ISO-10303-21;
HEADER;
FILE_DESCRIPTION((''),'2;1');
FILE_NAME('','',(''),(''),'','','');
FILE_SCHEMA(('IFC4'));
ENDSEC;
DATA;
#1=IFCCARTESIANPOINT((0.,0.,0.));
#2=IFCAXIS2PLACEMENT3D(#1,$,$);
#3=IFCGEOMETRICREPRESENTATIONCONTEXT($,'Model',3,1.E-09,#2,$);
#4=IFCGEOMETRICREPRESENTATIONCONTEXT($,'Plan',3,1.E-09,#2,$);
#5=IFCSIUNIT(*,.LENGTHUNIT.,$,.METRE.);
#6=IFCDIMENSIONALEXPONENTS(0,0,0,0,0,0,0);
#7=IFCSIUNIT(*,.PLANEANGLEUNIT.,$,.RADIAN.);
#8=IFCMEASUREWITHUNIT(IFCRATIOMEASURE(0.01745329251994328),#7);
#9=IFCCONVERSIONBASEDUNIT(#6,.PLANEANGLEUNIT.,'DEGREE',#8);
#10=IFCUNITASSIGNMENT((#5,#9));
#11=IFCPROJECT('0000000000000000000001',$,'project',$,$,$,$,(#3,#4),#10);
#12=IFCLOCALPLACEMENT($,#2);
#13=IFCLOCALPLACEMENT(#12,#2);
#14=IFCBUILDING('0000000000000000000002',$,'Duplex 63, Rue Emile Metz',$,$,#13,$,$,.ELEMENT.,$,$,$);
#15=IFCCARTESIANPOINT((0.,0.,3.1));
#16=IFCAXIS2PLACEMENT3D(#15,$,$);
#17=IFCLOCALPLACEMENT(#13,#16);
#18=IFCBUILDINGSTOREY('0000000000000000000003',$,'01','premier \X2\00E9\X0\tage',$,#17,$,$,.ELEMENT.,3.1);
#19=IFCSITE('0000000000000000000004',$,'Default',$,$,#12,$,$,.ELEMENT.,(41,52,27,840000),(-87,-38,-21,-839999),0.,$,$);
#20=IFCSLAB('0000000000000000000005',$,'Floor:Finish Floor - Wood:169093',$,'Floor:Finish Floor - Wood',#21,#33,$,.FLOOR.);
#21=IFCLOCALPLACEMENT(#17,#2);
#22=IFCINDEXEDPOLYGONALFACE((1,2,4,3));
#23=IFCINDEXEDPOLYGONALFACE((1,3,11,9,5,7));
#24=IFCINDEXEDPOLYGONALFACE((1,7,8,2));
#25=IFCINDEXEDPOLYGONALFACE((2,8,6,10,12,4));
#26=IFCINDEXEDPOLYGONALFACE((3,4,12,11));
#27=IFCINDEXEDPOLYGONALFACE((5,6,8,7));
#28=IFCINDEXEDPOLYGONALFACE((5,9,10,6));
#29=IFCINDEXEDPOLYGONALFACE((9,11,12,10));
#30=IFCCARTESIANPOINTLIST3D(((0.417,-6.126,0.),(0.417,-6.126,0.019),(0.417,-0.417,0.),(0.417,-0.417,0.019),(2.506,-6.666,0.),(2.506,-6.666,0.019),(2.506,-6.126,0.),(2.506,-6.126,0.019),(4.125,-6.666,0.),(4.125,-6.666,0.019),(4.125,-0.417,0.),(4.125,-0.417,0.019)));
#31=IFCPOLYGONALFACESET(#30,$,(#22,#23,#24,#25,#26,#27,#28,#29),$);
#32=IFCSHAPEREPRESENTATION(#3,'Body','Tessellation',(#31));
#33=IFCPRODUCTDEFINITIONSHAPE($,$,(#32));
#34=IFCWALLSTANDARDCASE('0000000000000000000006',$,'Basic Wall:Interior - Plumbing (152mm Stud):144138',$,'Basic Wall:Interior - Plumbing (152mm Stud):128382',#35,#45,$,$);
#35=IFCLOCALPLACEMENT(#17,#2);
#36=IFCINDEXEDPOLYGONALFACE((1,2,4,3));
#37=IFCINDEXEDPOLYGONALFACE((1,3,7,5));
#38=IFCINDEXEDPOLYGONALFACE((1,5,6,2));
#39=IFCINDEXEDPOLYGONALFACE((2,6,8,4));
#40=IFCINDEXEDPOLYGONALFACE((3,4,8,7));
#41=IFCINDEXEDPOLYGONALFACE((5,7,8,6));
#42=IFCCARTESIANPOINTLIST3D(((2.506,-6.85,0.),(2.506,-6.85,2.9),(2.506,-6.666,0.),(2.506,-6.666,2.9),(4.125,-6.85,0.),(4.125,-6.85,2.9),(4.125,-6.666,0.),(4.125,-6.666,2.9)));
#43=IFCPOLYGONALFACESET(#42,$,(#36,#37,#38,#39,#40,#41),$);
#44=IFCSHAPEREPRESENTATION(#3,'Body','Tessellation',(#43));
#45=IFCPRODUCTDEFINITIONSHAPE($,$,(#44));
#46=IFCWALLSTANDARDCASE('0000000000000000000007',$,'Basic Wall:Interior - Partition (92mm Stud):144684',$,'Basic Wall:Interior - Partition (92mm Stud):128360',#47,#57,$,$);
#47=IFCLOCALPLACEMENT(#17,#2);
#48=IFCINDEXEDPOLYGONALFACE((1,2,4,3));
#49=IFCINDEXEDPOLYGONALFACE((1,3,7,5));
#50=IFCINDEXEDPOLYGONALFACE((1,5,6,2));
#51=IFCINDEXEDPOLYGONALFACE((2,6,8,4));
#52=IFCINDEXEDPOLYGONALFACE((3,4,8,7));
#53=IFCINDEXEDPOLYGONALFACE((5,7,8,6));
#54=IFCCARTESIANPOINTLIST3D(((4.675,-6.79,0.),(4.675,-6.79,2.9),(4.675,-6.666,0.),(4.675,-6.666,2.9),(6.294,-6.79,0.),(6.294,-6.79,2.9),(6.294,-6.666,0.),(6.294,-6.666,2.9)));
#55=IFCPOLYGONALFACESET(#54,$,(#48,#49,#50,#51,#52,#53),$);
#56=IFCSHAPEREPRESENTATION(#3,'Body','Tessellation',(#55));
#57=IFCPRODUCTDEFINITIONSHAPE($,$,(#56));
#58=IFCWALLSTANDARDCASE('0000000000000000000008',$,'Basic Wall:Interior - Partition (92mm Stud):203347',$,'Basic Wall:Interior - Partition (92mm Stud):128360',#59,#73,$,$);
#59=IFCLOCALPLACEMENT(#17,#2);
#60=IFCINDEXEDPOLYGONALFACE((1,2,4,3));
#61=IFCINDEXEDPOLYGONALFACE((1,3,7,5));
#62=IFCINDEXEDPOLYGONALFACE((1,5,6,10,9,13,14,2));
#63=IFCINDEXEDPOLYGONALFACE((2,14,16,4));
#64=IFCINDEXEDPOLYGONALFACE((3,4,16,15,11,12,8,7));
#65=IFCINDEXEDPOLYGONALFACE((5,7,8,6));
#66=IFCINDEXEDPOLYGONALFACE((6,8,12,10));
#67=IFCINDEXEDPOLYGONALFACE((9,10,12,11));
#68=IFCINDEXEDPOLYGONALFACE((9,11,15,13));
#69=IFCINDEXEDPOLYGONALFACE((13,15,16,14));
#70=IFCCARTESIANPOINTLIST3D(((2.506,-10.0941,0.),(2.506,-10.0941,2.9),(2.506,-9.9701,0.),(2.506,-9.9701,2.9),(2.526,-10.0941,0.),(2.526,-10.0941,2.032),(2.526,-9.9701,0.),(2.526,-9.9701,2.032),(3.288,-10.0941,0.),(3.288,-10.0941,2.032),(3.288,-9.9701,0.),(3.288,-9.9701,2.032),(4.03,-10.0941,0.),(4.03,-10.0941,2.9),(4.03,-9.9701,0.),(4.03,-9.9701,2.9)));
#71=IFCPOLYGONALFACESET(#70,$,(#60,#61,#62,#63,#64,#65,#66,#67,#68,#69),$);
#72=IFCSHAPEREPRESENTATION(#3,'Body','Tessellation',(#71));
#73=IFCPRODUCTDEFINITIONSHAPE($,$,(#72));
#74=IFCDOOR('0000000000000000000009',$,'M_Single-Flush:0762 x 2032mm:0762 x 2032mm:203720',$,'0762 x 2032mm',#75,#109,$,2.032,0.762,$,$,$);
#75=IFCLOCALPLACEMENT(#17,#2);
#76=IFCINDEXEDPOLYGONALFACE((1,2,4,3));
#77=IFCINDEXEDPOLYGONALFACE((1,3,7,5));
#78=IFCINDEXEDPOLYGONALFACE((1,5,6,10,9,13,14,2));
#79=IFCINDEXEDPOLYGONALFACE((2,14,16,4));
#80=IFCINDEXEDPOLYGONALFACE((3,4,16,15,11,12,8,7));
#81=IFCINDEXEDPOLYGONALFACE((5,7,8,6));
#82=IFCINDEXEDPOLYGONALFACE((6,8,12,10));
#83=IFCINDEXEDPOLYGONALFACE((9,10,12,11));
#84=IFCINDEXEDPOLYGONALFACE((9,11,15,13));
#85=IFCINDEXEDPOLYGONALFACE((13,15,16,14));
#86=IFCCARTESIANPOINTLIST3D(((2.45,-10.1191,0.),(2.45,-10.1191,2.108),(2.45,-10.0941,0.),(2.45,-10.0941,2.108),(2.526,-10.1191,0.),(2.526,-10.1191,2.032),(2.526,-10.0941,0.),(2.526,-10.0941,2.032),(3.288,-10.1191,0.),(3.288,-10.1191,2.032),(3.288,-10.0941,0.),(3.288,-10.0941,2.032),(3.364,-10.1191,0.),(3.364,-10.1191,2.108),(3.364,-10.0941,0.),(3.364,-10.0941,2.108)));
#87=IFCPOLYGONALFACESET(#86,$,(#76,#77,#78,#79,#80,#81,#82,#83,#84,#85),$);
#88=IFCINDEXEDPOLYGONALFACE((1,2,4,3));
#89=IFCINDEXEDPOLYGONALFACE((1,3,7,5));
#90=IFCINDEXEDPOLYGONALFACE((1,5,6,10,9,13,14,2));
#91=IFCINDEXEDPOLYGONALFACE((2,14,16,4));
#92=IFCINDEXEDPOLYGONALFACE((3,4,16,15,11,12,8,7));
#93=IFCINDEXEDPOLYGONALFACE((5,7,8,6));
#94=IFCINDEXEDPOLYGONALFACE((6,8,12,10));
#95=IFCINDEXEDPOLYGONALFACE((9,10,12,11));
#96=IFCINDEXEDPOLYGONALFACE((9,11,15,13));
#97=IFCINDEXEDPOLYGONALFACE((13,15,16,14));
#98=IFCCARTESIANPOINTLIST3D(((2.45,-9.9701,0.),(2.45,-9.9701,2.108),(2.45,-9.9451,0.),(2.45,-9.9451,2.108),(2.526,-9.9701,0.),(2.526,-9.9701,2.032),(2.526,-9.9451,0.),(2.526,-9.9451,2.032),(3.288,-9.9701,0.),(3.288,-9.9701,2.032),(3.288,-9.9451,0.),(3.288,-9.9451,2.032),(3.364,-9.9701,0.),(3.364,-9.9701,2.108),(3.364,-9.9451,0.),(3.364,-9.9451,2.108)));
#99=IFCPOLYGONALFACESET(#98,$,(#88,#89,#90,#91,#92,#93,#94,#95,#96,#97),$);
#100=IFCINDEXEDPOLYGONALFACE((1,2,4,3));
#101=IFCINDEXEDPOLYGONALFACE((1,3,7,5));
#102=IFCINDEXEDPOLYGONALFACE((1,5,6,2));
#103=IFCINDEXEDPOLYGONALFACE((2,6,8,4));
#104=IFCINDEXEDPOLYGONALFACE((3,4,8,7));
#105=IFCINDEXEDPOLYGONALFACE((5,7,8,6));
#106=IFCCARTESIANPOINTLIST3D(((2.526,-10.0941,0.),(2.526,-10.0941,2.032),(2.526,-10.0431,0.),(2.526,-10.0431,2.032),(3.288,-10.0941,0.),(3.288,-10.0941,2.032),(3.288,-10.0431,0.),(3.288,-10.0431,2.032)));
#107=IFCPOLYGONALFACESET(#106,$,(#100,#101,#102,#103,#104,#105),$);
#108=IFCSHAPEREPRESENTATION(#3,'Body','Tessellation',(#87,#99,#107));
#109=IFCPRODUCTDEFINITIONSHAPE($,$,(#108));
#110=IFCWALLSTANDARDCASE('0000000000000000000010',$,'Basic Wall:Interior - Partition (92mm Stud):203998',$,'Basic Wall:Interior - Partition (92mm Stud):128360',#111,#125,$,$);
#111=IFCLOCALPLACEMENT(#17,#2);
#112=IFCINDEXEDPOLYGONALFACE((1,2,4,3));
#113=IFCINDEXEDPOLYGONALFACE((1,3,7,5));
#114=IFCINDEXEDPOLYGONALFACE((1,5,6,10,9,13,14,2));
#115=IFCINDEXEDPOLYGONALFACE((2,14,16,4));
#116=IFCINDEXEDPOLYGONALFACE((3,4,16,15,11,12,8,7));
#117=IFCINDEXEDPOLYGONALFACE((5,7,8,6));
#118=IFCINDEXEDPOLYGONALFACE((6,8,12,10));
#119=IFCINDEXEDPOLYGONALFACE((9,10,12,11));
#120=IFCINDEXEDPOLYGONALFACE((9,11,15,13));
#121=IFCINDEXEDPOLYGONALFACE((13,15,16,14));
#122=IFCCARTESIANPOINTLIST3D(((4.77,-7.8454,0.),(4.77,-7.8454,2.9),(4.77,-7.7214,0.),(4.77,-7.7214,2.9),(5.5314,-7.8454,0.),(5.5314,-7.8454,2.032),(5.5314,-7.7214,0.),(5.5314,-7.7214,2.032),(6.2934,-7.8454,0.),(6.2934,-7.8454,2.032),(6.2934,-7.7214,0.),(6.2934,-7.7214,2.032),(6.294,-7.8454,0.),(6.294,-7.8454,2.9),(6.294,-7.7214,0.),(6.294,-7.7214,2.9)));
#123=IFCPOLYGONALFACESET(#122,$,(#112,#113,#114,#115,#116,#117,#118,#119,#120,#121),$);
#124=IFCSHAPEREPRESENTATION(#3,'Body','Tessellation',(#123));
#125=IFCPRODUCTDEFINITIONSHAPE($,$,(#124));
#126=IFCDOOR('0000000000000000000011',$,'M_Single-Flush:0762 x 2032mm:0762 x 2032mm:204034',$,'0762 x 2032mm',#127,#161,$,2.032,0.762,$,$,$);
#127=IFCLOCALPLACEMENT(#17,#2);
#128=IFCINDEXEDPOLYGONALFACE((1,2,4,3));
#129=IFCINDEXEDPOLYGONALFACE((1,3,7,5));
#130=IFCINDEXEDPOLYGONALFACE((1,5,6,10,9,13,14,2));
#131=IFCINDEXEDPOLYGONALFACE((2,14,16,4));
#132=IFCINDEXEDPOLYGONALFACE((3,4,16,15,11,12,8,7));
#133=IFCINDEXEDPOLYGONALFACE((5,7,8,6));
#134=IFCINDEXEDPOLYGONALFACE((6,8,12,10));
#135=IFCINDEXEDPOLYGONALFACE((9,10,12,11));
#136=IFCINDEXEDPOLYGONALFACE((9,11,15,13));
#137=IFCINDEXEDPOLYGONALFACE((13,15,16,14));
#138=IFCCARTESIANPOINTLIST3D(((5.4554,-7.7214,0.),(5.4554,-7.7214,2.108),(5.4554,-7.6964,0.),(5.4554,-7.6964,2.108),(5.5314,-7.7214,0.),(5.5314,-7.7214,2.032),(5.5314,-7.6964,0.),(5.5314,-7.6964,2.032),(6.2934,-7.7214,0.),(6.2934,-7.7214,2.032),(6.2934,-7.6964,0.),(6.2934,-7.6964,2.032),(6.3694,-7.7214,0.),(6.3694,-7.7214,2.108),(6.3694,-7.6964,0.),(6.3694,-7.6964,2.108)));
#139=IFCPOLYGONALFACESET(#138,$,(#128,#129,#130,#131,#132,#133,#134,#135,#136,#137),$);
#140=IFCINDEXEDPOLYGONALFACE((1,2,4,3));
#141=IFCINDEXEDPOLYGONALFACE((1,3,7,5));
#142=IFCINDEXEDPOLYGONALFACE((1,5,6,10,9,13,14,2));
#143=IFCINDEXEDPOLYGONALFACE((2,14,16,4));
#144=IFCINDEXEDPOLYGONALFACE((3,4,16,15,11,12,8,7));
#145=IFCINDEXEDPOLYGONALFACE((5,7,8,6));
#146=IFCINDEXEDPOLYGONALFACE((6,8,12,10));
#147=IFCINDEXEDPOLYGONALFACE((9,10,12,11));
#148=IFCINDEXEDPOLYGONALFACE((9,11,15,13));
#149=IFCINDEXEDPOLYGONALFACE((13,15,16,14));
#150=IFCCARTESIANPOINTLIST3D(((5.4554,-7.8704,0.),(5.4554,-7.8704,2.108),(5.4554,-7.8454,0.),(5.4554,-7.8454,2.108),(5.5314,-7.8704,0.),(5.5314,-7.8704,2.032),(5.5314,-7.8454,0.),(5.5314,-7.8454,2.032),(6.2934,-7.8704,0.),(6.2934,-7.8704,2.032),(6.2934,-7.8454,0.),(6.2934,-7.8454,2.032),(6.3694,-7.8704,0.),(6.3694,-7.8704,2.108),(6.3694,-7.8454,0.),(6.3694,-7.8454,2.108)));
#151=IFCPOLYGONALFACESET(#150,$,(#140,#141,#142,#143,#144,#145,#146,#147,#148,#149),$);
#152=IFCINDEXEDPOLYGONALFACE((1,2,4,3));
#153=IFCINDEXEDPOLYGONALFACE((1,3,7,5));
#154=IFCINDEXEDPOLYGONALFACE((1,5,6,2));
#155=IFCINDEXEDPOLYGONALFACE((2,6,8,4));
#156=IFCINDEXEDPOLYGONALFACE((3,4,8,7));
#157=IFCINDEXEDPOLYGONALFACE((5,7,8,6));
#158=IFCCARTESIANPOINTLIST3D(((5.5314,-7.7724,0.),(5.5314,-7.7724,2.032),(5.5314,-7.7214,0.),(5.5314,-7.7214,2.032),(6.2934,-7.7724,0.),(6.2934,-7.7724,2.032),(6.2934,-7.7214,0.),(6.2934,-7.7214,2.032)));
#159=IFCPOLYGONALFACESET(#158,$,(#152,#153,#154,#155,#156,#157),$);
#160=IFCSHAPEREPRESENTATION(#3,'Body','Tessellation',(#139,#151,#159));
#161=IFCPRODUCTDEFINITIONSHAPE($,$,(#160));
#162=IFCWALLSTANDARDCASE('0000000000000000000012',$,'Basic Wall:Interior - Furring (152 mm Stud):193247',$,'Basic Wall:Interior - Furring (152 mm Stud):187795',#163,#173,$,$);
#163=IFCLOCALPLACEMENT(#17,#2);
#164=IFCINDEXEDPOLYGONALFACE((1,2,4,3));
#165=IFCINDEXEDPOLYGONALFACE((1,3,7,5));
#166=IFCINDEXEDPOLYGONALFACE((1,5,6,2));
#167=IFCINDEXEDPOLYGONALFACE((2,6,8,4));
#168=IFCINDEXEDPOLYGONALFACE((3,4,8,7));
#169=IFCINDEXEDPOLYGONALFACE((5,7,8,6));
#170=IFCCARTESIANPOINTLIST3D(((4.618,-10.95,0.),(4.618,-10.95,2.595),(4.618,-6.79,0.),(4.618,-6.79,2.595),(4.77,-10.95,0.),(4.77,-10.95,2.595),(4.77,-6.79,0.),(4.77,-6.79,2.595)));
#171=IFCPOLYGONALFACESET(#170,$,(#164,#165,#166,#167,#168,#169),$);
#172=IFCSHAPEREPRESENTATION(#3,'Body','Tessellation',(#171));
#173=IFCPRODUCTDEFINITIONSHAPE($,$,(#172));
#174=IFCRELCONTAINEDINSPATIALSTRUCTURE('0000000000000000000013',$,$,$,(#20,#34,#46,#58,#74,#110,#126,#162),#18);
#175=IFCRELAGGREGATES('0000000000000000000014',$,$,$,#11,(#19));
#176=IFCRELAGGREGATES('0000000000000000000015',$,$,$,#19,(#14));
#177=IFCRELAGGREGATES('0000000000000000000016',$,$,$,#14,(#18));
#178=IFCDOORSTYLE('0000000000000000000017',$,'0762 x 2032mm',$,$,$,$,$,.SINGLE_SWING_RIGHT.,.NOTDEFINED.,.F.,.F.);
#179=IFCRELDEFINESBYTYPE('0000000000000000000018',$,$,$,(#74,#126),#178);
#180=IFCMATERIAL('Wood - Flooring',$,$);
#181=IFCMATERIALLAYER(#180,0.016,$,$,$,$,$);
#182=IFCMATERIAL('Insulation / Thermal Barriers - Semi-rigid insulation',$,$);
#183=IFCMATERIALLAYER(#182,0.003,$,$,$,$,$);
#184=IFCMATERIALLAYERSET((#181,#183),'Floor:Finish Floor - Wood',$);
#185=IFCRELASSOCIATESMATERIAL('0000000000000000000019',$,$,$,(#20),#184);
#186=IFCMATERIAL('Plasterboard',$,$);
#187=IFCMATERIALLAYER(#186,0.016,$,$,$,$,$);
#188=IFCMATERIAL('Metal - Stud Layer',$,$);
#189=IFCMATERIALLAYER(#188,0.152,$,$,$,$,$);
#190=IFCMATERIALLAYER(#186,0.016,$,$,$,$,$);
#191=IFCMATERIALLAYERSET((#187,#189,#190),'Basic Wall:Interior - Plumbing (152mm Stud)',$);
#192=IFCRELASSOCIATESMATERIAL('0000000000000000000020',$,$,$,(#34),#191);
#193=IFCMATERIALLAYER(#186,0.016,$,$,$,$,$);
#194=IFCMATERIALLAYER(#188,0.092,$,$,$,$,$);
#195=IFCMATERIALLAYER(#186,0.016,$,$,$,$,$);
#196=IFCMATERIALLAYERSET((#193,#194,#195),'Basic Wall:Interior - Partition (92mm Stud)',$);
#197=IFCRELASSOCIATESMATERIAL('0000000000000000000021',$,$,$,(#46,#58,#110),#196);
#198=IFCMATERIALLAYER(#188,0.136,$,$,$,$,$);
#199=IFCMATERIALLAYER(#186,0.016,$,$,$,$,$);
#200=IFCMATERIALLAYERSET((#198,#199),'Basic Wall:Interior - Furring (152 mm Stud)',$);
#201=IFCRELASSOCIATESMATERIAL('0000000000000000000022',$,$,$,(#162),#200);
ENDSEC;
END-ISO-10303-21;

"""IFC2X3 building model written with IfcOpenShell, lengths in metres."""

from ifc_helpers import new_model, entity, si_unit, converted_unit, frame, frame_2d, origin, origin_2d_with_axis, place, context, project, spatial, polyline, rectangle, outline, extrude, source, transform, mapped, material, layer, layer_set, layer_usage, type_object, type_shapes, element, fill, save


model = new_model("IFC2X3")

# Units and contexts
model_context = context("Model", 3, precision=1e-09, world=origin())
plan_context = context("Plan", 3, precision=1e-09, world=origin())
ifc_project = project(units=[si_unit("LENGTHUNIT", "METRE"), converted_unit("PLANEANGLEUNIT", "DEGREE", entity("IfcRatioMeasure", 0.01745329251994328), si_unit("PLANEANGLEUNIT", "RADIAN"), dimensions=[0, 0, 0, 0, 0, 0, 0])], contexts=[model_context, plan_context])

# Site, building, storey
site_placement = place(None, origin())
site = spatial("IfcSite", under=ifc_project, at=site_placement, Name="Default", CompositionType="ELEMENT", RefLatitude=(41, 52, 27, 840000), RefLongitude=(-87, -38, -21, -839999), RefElevation=0.0)
building_placement = place(site_placement, origin())
building = spatial("IfcBuilding", under=site, at=building_placement, Name="Duplex 63, Rue Emile Metz", CompositionType="ELEMENT")
storey_placement = place(building_placement, frame((0.0, 0.0, 3.1)))
storey = spatial("IfcBuildingStorey", under=building, at=storey_placement, Name="01", Description="premier étage", CompositionType="ELEMENT", Elevation=3.1)

# Slab
ifc_material_1 = material(Name="Wood - Flooring")
ifc_layer_1 = layer(ifc_material_1, 0.016)
ifc_material_2 = material(Name="Insulation / Thermal Barriers - Semi-rigid insulation")
ifc_layer_2 = layer(ifc_material_2, 0.003)
ifc_layer_set_1 = layer_set([ifc_layer_1, ifc_layer_2], Name="Floor:Finish Floor - Wood")
ifc_layer_usage_1 = layer_usage(ifc_layer_set_1, "AXIS3", "POSITIVE", 0.0)
slab_placement = place(storey_placement, frame((0.417, -6.666, 0.0)))
element("IfcSlab", 1, at=slab_placement, inside=storey, material=ifc_layer_usage_1, Name="Floor:Finish Floor - Wood:169093", ObjectType="Floor:Finish Floor - Wood", PredefinedType="FLOOR", context=model_context, shape_type="SweptSolid", body=[
    extrude(outline(polyline([(1.854, 3.1245), (-1.854, 3.1245), (-1.854, -3.1245), (-0.235, -3.1245), (-0.235, -2.5845), (1.854, -2.5845), (1.854, 3.1245)])), frame((1.854, 3.1245, 0.019), z_axis=(0.0, 0.0, -1.0), x_axis=(-1.0, 0.0, 0.0)), (0.0, 0.0, 1.0), 0.019),
])

# Walls
ifc_material_3 = material(Name="Plasterboard")
ifc_layer_3 = layer(ifc_material_3, 0.016)
ifc_material_4 = material(Name="Metal - Stud Layer")
ifc_layer_4 = layer(ifc_material_4, 0.152)
ifc_layer_5 = layer(ifc_material_3, 0.016)
ifc_layer_set_2 = layer_set([ifc_layer_3, ifc_layer_4, ifc_layer_5], Name="Basic Wall:Interior - Plumbing (152mm Stud)")
ifc_layer_usage_2 = layer_usage(ifc_layer_set_2, "AXIS2", "NEGATIVE", 0.092)
wall_1_placement = place(storey_placement, frame((2.506, -6.758, 0.0)))
element("IfcWallStandardCase", 2, at=wall_1_placement, inside=storey, material=ifc_layer_usage_2, Name="Basic Wall:Interior - Plumbing (152mm Stud):144138", ObjectType="Basic Wall:Interior - Plumbing (152mm Stud):128382", context=model_context, shape_type="SweptSolid", body=[
    extrude(rectangle(XDim=1.619, YDim=0.184, at=frame_2d((0.8095, 0.0), x_axis=(-1.0, 0.0))), origin(), (0.0, 0.0, 1.0), 2.9),
])
ifc_layer_6 = layer(ifc_material_3, 0.016)
ifc_layer_7 = layer(ifc_material_4, 0.092)
ifc_layer_8 = layer(ifc_material_3, 0.016)
ifc_layer_set_3 = layer_set([ifc_layer_6, ifc_layer_7, ifc_layer_8], Name="Basic Wall:Interior - Partition (92mm Stud)")
ifc_layer_usage_3 = layer_usage(ifc_layer_set_3, "AXIS2", "NEGATIVE", 0.062)
wall_2_placement = place(storey_placement, frame((4.675, -6.728, 0.0)))
element("IfcWallStandardCase", 3, at=wall_2_placement, inside=storey, material=ifc_layer_usage_3, Name="Basic Wall:Interior - Partition (92mm Stud):144684", ObjectType="Basic Wall:Interior - Partition (92mm Stud):128360", context=model_context, shape_type="SweptSolid", body=[
    extrude(rectangle(XDim=1.619, YDim=0.124, at=frame_2d((0.8095, 0.0), x_axis=(-1.0, 0.0))), origin(), (0.0, 0.0, 1.0), 2.9),
])

# Walls, openings, doors
wall_3_placement = place(storey_placement, frame((4.03, -10.0321, 0.0), z_axis=(0.0, 0.0, 1.0), x_axis=(-1.0, 0.0, 0.0)))
wall_3 = element("IfcWallStandardCase", 4, at=wall_3_placement, inside=storey, material=ifc_layer_usage_3, Name="Basic Wall:Interior - Partition (92mm Stud):203347", ObjectType="Basic Wall:Interior - Partition (92mm Stud):128360", context=model_context, shape_type="SweptSolid", body=[
    extrude(rectangle(XDim=1.524, YDim=0.124, at=frame_2d((0.762, 0.0), x_axis=(-1.0, 0.0))), origin(), (0.0, 0.0, 1.0), 2.9),
])
opening_1_placement = place(wall_3_placement, frame((0.742, -0.062, 0.0)))
opening_1 = element("IfcOpeningElement", 5, at=opening_1_placement, cuts=wall_3, ObjectType="Opening", context=model_context, shape_type="SweptSolid", body=[
    extrude(rectangle(XDim=0.762, YDim=2.032, at=frame_2d((1.016, 0.381), x_axis=(0.0, 1.0))), frame((0.0, 0.0, 0.0), z_axis=(0.0, 1.0, 0.0), x_axis=(0.0, 0.0, 1.0)), (0.0, 0.0, 1.0), 0.124),
])
door_style = type_object("IfcDoorStyle", Name="0762 x 2032mm", ConstructionType="NOTDEFINED", OperationType="SINGLE_SWING_RIGHT", ParameterTakesPrecedence=False, Sizeable=False)
shared_shape = source(origin(), model_context, "Body", "SweptSolid", [
    extrude(outline(polyline([(-0.457, -1.073), (0.457, -1.073), (0.457, 1.035), (0.381, 1.035), (0.381, -0.997), (-0.381, -0.997), (-0.381, 1.035), (-0.457, 1.035), (-0.457, -1.073)])), frame((0.381, 0.124, 1.035), z_axis=(0.0, 1.0, 0.0), x_axis=(1.0, 0.0, 0.0)), (0.0, 0.0, 1.0), 0.025),
    extrude(outline(polyline([(-1.073, -0.457), (1.035, -0.457), (1.035, -0.381), (-0.997, -0.381), (-0.997, 0.381), (1.035, 0.381), (1.035, 0.457), (-1.073, 0.457), (-1.073, -0.457)])), frame((0.381, -0.025, 1.035), z_axis=(0.0, 1.0, 0.0), x_axis=(0.0, 0.0, -1.0)), (0.0, 0.0, 1.0), 0.025),
    extrude(rectangle(XDim=0.051, YDim=0.762, at=origin_2d_with_axis()), frame((0.381, 0.0985, 0.0), z_axis=(0.0, 0.0, 1.0), x_axis=(0.0, 1.0, 0.0)), (0.0, 0.0, 1.0), 2.032),
])
type_shapes(door_style, [shared_shape])
door_1_placement = place(opening_1_placement, origin())
door_1 = element("IfcDoor", 6, at=door_1_placement, inside=storey, type_object=door_style, Name="M_Single-Flush:0762 x 2032mm:0762 x 2032mm:203720", ObjectType="0762 x 2032mm", OverallHeight=2.032, OverallWidth=0.762, context=model_context, shape_type="MappedRepresentation", body=[
    mapped(shared_shape, transform((0.0, 0.0, 0.0), scale=1.0)),
])
fill(opening_1, door_1)
ifc_layer_usage_4 = layer_usage(ifc_layer_set_3, "AXIS2", "POSITIVE", -0.062)
wall_4_placement = place(storey_placement, frame((4.77, -7.7834, 0.0)))
wall_4 = element("IfcWallStandardCase", 7, at=wall_4_placement, inside=storey, material=ifc_layer_usage_4, Name="Basic Wall:Interior - Partition (92mm Stud):203998", ObjectType="Basic Wall:Interior - Partition (92mm Stud):128360", context=model_context, shape_type="SweptSolid", body=[
    extrude(rectangle(XDim=1.524, YDim=0.124, at=frame_2d((0.762, 0.0), x_axis=(-1.0, 0.0))), origin(), (0.0, 0.0, 1.0), 2.9),
])
opening_2_placement = place(wall_4_placement, frame((0.7614, -0.062, 0.0)))
opening_2 = element("IfcOpeningElement", 8, at=opening_2_placement, cuts=wall_4, ObjectType="Opening", context=model_context, shape_type="SweptSolid", body=[
    extrude(rectangle(XDim=0.762, YDim=2.032, at=frame_2d((1.016, 0.381), x_axis=(0.0, 1.0))), frame((0.0, 0.0, 0.0), z_axis=(0.0, 1.0, 0.0), x_axis=(0.0, 0.0, 1.0)), (0.0, 0.0, 1.0), 0.124),
])
door_2_placement = place(opening_2_placement, origin())
door_2 = element("IfcDoor", 9, at=door_2_placement, inside=storey, type_object=door_style, Name="M_Single-Flush:0762 x 2032mm:0762 x 2032mm:204034", ObjectType="0762 x 2032mm", OverallHeight=2.032, OverallWidth=0.762, context=model_context, shape_type="MappedRepresentation", body=[
    mapped(shared_shape, transform((0.0, 0.0, 0.0), scale=1.0)),
])
fill(opening_2, door_2)

# Wall
ifc_layer_9 = layer(ifc_material_4, 0.136)
ifc_layer_10 = layer(ifc_material_3, 0.016)
ifc_layer_set_4 = layer_set([ifc_layer_9, ifc_layer_10], Name="Basic Wall:Interior - Furring (152 mm Stud)")
ifc_layer_usage_5 = layer_usage(ifc_layer_set_4, "AXIS2", "POSITIVE", -0.076)
wall_5_placement = place(storey_placement, frame((4.694, -6.79, 0.0), z_axis=(0.0, 0.0, 1.0), x_axis=(0.0, -1.0, 0.0)))
element("IfcWallStandardCase", 10, at=wall_5_placement, inside=storey, material=ifc_layer_usage_5, Name="Basic Wall:Interior - Furring (152 mm Stud):193247", ObjectType="Basic Wall:Interior - Furring (152 mm Stud):187795", context=model_context, shape_type="SweptSolid", body=[
    extrude(rectangle(XDim=4.16, YDim=0.152, at=frame_2d((2.08, 0.0), x_axis=(-1.0, 0.0))), origin(), (0.0, 0.0, 1.0), 2.595),
])

save(model, "model.ifc")
